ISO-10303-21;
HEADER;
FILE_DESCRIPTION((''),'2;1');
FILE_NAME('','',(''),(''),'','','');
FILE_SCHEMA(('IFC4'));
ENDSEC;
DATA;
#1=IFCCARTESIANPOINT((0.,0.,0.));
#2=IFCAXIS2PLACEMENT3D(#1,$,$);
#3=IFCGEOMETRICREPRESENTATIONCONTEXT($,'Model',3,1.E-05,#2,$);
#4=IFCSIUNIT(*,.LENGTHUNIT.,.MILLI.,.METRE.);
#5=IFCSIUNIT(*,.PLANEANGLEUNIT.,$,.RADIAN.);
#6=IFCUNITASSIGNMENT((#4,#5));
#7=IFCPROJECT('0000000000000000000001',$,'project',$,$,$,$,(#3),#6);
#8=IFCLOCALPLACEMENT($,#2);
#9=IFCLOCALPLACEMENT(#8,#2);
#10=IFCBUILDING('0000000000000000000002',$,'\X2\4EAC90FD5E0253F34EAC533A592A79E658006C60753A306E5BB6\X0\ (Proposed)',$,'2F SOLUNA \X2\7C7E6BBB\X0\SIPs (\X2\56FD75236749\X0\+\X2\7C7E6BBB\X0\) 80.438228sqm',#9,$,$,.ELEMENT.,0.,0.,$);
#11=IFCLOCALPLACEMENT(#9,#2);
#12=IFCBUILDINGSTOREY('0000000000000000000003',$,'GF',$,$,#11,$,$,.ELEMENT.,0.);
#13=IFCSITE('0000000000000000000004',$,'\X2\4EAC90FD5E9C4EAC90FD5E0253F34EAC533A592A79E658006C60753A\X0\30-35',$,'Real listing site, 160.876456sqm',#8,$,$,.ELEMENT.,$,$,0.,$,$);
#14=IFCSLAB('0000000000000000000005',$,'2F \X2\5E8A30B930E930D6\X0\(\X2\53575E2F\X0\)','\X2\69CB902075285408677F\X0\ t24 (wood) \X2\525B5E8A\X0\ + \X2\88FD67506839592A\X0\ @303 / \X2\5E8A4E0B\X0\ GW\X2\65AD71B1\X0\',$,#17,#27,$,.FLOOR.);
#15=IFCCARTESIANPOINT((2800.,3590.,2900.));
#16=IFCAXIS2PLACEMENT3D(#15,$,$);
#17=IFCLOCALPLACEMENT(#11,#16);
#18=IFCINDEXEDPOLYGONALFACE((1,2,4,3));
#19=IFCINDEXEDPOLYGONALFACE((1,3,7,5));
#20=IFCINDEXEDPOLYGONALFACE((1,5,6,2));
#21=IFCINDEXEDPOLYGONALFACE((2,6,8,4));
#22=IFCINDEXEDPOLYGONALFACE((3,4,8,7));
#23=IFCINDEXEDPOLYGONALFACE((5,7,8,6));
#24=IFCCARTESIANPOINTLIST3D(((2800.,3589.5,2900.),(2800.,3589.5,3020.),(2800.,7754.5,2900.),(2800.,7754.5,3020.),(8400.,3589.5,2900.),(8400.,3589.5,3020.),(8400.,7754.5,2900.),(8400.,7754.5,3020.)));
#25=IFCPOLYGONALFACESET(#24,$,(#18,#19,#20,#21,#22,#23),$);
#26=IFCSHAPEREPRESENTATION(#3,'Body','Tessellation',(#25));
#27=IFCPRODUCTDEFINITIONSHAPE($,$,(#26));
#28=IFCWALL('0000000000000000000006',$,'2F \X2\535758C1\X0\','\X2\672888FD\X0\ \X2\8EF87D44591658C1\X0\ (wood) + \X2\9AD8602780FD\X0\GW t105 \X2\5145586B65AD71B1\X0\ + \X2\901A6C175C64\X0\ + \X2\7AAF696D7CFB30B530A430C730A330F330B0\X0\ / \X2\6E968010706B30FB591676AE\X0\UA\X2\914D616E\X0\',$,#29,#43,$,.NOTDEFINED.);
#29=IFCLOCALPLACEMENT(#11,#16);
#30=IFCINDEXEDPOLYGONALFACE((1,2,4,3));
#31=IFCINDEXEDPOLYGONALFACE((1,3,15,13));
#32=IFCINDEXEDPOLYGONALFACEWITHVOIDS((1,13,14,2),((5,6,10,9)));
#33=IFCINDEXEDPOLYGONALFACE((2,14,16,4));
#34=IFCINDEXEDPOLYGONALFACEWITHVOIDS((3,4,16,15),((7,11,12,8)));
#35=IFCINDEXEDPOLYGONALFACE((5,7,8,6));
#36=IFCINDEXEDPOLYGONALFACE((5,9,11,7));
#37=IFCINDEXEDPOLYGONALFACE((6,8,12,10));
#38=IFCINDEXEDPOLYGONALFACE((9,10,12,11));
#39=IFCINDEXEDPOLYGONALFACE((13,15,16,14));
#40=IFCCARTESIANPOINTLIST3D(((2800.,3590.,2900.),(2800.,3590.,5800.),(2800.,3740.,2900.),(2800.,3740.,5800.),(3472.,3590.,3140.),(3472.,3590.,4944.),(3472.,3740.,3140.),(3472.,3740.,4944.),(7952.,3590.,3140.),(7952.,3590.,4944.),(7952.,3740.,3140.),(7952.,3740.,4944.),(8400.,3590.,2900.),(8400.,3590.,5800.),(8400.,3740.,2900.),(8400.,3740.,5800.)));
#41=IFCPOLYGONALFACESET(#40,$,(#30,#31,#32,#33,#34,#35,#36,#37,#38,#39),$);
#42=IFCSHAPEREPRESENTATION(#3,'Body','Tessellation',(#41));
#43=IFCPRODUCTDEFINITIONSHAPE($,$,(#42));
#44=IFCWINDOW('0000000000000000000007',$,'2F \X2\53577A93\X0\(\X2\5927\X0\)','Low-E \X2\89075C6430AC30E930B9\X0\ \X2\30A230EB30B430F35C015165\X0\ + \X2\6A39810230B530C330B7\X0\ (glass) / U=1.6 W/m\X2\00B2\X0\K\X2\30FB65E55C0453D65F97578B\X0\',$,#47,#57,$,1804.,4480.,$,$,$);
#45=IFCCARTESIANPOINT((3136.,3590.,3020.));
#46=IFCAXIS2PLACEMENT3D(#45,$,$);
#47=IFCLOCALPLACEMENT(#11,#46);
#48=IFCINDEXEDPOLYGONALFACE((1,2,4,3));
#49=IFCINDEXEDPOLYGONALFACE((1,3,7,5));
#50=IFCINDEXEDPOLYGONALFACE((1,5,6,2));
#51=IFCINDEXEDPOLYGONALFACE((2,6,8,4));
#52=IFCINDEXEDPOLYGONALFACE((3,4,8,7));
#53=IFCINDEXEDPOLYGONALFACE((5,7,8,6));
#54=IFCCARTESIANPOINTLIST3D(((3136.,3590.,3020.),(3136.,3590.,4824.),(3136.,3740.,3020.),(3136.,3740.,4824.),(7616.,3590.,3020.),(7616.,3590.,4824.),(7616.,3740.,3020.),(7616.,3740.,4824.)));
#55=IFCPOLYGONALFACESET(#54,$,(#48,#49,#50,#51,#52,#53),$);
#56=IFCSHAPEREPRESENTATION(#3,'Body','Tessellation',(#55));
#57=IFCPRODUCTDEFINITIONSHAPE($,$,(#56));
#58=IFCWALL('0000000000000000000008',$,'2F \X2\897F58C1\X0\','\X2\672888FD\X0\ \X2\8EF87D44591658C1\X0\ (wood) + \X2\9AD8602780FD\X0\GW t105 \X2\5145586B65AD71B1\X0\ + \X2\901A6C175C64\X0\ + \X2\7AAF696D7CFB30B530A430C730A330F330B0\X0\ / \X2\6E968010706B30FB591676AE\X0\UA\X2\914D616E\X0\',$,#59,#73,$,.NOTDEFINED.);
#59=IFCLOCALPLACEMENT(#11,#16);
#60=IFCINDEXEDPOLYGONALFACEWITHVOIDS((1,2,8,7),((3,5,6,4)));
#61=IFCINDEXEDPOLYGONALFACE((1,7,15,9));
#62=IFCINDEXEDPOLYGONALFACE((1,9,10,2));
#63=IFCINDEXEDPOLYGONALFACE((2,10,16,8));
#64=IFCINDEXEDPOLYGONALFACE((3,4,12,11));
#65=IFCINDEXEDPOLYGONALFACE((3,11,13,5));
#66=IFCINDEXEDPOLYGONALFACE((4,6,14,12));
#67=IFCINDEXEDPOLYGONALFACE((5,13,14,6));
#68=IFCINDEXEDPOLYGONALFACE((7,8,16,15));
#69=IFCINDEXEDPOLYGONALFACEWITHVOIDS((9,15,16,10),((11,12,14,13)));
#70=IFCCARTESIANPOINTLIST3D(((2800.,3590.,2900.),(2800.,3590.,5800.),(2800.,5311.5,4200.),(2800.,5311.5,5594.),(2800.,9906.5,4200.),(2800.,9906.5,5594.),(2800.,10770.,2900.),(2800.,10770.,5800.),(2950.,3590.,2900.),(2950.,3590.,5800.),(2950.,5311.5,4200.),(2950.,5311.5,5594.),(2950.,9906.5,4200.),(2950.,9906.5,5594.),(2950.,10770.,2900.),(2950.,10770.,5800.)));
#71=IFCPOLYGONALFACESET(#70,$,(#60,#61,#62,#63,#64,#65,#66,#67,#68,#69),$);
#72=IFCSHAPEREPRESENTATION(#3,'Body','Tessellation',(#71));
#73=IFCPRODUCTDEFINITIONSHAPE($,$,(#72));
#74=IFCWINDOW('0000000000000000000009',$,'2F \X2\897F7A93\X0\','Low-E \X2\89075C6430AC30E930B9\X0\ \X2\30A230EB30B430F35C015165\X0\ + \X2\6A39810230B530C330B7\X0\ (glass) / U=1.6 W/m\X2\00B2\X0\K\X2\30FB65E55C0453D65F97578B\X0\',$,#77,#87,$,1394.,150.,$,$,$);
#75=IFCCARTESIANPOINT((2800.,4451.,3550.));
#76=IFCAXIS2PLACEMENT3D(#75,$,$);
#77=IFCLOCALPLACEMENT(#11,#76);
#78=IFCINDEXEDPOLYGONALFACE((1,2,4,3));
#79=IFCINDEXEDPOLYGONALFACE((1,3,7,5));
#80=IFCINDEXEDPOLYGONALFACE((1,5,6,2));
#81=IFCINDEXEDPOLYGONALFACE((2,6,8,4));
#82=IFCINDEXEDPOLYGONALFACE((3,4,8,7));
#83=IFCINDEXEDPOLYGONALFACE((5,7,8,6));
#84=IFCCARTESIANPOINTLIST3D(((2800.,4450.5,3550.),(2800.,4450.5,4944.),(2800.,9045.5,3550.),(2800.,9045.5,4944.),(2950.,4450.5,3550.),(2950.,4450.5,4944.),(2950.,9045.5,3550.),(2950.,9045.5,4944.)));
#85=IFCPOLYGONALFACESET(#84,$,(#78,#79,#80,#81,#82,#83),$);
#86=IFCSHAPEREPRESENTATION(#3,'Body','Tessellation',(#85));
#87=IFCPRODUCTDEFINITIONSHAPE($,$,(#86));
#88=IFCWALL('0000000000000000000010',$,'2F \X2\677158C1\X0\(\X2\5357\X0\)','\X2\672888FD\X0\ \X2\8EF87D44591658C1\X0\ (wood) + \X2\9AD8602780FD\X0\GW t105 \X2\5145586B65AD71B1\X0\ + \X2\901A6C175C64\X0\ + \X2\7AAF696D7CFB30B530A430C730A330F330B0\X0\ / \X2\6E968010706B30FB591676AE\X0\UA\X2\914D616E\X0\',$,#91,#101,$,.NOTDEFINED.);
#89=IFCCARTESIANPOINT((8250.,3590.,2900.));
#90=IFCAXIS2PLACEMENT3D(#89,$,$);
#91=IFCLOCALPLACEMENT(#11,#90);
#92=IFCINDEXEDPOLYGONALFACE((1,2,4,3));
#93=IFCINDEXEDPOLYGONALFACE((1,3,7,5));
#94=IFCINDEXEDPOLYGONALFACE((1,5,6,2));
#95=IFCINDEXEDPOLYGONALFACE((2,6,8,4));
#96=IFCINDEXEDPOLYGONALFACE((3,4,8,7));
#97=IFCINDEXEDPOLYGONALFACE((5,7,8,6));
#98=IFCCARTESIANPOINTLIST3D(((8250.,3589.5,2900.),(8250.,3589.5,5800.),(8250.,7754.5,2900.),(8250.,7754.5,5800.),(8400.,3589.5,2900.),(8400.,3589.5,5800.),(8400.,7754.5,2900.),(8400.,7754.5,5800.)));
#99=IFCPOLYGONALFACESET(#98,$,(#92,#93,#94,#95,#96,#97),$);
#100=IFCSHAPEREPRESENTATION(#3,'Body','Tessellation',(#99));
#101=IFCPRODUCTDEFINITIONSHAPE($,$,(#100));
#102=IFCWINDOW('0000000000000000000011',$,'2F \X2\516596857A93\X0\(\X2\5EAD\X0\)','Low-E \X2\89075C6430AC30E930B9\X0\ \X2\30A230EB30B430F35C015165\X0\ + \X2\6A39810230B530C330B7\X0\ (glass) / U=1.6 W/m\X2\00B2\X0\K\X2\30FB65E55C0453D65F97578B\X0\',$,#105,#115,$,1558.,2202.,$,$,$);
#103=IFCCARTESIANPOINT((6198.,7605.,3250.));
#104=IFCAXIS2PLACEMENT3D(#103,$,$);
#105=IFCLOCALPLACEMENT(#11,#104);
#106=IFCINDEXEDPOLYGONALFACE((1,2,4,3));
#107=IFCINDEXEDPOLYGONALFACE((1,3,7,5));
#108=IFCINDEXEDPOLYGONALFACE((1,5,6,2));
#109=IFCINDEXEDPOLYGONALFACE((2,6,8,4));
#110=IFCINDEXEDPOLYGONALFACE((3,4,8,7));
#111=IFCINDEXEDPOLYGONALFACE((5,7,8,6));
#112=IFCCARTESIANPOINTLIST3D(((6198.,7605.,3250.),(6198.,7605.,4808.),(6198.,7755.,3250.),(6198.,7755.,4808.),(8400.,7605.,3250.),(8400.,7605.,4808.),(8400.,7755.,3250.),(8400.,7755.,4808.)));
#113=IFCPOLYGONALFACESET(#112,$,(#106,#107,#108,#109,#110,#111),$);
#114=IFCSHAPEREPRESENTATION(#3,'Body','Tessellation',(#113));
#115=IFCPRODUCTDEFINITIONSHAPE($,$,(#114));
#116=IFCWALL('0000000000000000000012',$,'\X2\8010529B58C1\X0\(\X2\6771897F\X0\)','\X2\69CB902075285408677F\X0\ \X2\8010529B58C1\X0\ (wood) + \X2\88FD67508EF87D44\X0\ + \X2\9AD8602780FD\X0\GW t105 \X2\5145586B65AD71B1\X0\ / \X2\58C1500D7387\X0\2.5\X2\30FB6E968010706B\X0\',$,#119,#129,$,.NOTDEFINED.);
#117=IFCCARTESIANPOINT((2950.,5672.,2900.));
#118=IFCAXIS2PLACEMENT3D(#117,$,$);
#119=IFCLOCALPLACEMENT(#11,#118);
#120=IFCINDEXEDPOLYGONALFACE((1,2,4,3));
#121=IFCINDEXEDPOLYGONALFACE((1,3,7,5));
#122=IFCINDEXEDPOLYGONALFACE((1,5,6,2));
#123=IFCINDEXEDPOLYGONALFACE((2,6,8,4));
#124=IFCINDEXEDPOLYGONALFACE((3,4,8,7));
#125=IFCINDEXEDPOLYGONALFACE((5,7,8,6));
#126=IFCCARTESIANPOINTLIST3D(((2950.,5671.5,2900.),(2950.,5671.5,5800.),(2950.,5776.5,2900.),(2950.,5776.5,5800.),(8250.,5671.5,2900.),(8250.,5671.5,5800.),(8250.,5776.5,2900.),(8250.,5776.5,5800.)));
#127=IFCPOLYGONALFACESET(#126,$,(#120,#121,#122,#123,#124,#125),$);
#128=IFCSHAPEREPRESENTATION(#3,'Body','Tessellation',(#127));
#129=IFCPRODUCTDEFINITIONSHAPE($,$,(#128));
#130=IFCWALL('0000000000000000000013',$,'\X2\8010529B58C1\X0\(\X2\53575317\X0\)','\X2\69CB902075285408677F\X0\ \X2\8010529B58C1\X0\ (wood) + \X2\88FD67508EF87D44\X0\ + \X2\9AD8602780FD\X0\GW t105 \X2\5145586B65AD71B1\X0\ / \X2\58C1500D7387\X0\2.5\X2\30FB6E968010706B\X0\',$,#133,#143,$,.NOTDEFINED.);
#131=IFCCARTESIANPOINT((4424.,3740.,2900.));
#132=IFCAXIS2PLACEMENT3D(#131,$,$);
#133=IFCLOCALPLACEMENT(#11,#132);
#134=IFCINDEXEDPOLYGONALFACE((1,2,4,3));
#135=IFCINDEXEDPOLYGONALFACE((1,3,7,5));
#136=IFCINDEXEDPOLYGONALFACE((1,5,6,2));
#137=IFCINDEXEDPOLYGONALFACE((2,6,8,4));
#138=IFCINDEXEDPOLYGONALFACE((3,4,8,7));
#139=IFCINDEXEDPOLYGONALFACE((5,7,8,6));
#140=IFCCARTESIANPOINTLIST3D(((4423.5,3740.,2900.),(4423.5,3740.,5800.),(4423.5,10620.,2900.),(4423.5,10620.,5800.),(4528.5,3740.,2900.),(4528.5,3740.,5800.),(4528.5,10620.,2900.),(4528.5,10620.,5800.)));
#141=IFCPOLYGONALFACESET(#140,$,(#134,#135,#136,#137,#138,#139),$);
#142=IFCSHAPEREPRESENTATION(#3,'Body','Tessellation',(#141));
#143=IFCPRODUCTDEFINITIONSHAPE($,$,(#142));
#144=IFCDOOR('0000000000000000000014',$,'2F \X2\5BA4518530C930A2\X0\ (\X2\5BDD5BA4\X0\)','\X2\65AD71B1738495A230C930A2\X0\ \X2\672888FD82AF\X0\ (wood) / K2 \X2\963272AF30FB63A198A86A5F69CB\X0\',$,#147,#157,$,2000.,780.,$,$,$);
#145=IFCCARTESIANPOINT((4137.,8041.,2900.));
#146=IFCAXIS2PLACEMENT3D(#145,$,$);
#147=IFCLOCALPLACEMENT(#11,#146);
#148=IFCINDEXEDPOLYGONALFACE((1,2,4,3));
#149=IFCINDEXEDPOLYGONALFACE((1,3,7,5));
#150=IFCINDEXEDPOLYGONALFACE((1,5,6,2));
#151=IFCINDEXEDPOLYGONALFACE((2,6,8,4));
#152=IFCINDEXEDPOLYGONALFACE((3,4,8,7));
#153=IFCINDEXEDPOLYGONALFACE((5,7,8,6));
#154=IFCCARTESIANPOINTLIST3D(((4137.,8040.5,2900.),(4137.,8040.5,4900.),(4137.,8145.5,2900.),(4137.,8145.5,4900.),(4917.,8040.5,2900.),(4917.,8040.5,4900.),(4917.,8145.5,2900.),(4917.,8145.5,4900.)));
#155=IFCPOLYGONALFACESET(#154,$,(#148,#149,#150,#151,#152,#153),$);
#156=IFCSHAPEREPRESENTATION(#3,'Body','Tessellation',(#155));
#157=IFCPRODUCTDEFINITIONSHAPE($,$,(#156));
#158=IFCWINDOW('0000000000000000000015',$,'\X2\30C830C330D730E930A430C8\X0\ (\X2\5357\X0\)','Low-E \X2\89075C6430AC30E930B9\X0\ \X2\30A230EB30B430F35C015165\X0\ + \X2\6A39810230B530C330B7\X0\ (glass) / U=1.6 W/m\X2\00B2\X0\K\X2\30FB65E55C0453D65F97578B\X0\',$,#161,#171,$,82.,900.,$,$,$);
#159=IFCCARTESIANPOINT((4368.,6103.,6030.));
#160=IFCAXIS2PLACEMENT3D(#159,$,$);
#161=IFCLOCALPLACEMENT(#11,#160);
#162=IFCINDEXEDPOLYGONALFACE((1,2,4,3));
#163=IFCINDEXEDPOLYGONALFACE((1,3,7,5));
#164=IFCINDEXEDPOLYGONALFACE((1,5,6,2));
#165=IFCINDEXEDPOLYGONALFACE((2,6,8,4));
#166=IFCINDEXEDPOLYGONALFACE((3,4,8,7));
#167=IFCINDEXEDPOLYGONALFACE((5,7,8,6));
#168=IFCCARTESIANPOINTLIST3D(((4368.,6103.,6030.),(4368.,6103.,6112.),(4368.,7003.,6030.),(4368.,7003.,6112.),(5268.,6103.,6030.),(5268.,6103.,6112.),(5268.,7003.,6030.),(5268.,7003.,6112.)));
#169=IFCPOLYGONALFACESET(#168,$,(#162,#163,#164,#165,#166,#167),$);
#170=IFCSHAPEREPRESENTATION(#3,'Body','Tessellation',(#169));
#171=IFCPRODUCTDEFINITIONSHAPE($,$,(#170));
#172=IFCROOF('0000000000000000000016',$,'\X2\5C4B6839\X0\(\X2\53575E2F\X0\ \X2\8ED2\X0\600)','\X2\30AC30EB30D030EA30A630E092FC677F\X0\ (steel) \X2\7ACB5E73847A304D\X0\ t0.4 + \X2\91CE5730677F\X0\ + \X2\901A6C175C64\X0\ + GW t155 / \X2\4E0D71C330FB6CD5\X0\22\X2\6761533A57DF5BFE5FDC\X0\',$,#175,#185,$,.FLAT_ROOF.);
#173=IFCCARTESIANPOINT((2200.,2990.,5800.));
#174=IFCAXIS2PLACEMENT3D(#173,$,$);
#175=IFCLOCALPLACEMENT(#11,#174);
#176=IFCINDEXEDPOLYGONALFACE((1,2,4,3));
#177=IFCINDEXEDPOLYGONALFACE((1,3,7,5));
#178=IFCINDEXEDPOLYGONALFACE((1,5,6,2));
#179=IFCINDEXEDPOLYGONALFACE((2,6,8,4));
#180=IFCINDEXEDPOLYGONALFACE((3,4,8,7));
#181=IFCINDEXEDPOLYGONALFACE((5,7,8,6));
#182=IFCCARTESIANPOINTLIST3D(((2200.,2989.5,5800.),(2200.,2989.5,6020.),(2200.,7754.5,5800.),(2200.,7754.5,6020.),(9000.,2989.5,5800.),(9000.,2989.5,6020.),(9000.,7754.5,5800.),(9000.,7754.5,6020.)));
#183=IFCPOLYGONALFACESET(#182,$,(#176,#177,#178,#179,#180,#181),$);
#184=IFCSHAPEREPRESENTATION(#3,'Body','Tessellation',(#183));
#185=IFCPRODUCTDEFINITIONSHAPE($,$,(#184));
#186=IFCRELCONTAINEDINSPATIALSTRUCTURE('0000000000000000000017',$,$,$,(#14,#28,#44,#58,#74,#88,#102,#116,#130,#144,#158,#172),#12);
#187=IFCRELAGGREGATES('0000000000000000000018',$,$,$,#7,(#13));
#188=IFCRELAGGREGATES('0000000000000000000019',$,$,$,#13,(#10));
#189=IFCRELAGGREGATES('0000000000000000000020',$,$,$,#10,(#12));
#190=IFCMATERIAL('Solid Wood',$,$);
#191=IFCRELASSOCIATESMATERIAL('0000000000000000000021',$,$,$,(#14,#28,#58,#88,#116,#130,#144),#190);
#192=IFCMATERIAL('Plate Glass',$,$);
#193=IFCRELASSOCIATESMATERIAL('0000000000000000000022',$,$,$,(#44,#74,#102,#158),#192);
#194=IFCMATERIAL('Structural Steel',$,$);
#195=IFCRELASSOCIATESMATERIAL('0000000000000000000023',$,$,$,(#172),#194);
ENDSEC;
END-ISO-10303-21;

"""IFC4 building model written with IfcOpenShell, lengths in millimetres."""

from ifc_helpers import new_model, si_unit, frame, frame_2d, origin, place, context, project, spatial, rectangle, extrude, material, element, fill, save


model = new_model("IFC4")

# Units and contexts
model_context = context("Model", 3, precision=1e-05, world=origin())
ifc_project = project(units=[si_unit("LENGTHUNIT", "METRE", prefix="MILLI"), si_unit("PLANEANGLEUNIT", "RADIAN")], contexts=[model_context])

# Site, building, storey
site_placement = place(None, origin())
site = spatial("IfcSite", under=ifc_project, at=site_placement, Name="京都府京都市右京区太秦堀池町30-35", ObjectType="Real listing site, 160.876456sqm", CompositionType="ELEMENT", RefElevation=0.0)
building_placement = place(site_placement, origin())
building = spatial("IfcBuilding", under=site, at=building_placement, Name="京都市右京区太秦堀池町の家 (Proposed)", ObjectType="2F SOLUNA 籾殻SIPs (国産杉+籾殻) 80.438228sqm", CompositionType="ELEMENT", ElevationOfRefHeight=0.0, ElevationOfTerrain=0.0)
storey_placement = place(building_placement, origin())
storey = spatial("IfcBuildingStorey", under=building, at=storey_placement, Name="GF", CompositionType="ELEMENT", Elevation=0.0)

# Slab
ifc_material_1 = material(Name="Solid Wood")
slab_placement = place(storey_placement, frame((2800.0, 3590.0, 2900.0)))
element("IfcSlab", 1, at=slab_placement, inside=storey, material=ifc_material_1, Name="2F 床スラブ(南帯)", Description="構造用合板 t24 (wood) 剛床 + 製材根太 @303 / 床下 GW断熱", PredefinedType="FLOOR", context=model_context, shape_type="SweptSolid", body=[
    extrude(rectangle(XDim=5600.0, YDim=4165.0, at=frame_2d((2800.0, 2082.0))), frame((2800.0, 3590.0, 2900.0)), (0.0, 0.0, 1.0), 120.0),
])

# Walls, openings, windows
wall_1_placement = place(storey_placement, frame((2800.0, 3590.0, 2900.0)))
wall_1 = element("IfcWall", 2, at=wall_1_placement, inside=storey, material=ifc_material_1, Name="2F 南壁", Description="木製 軸組外壁 (wood) + 高性能GW t105 充填断熱 + 通気層 + 窯業系サイディング / 準耐火・外皮UA配慮", PredefinedType="NOTDEFINED", context=model_context, shape_type="SweptSolid", body=[
    extrude(rectangle(XDim=5600.0, YDim=150.0, at=frame_2d((2800.0, 75.0))), frame((2800.0, 3590.0, 2900.0)), (0.0, 0.0, 1.0), 2900.0),
])
opening_1_placement = place(storey_placement, frame((3136.0, 3590.0, 3020.0)))
opening_1 = element("IfcOpeningElement", 3, at=opening_1_placement, cuts=wall_1, PredefinedType="NOTDEFINED", context=model_context, shape_type="SweptSolid", body=[
    extrude(rectangle(XDim=4480.0, YDim=150.0, at=frame_2d((2240.0, 75.0))), frame((3136.0, 3590.0, 3020.0)), (0.0, 0.0, 1.0), 1804.0),
])
ifc_material_2 = material(Name="Plate Glass")
window_1_placement = place(storey_placement, frame((3136.0, 3590.0, 3020.0)))
window_1 = element("IfcWindow", 4, at=window_1_placement, inside=storey, material=ifc_material_2, Name="2F 南窓(大)", Description="Low-E 複層ガラス アルゴン封入 + 樹脂サッシ (glass) / U=1.6 W/m²K・日射取得型", OverallHeight=1804.0, OverallWidth=4480.0, context=model_context, shape_type="SweptSolid", body=[
    extrude(rectangle(XDim=4480.0, YDim=150.0, at=frame_2d((2240.0, 75.0))), frame((3136.0, 3590.0, 3020.0)), (0.0, 0.0, 1.0), 1804.0),
])
fill(opening_1, window_1)
wall_2_placement = place(storey_placement, frame((2800.0, 3590.0, 2900.0)))
wall_2 = element("IfcWall", 5, at=wall_2_placement, inside=storey, material=ifc_material_1, Name="2F 西壁", Description="木製 軸組外壁 (wood) + 高性能GW t105 充填断熱 + 通気層 + 窯業系サイディング / 準耐火・外皮UA配慮", PredefinedType="NOTDEFINED", context=model_context, shape_type="SweptSolid", body=[
    extrude(rectangle(XDim=150.0, YDim=7180.0, at=frame_2d((75.0, 3590.0))), frame((2800.0, 3590.0, 2900.0)), (0.0, 0.0, 1.0), 2900.0),
])
opening_2_placement = place(storey_placement, frame((2800.0, 4451.0, 3550.0)))
opening_2 = element("IfcOpeningElement", 6, at=opening_2_placement, cuts=wall_2, PredefinedType="NOTDEFINED", context=model_context, shape_type="SweptSolid", body=[
    extrude(rectangle(XDim=150.0, YDim=4595.0, at=frame_2d((75.0, 2297.0))), frame((2800.0, 4451.0, 3550.0)), (0.0, 0.0, 1.0), 1394.0),
])
window_2_placement = place(storey_placement, frame((2800.0, 4451.0, 3550.0)))
window_2 = element("IfcWindow", 7, at=window_2_placement, inside=storey, material=ifc_material_2, Name="2F 西窓", Description="Low-E 複層ガラス アルゴン封入 + 樹脂サッシ (glass) / U=1.6 W/m²K・日射取得型", OverallHeight=1394.0, OverallWidth=150.0, context=model_context, shape_type="SweptSolid", body=[
    extrude(rectangle(XDim=150.0, YDim=4595.0, at=frame_2d((75.0, 2297.0))), frame((2800.0, 4451.0, 3550.0)), (0.0, 0.0, 1.0), 1394.0),
])
fill(opening_2, window_2)
wall_3_placement = place(storey_placement, frame((8250.0, 3590.0, 2900.0)))
wall_3 = element("IfcWall", 8, at=wall_3_placement, inside=storey, material=ifc_material_1, Name="2F 東壁(南)", Description="木製 軸組外壁 (wood) + 高性能GW t105 充填断熱 + 通気層 + 窯業系サイディング / 準耐火・外皮UA配慮", PredefinedType="NOTDEFINED", context=model_context, shape_type="SweptSolid", body=[
    extrude(rectangle(XDim=150.0, YDim=4165.0, at=frame_2d((75.0, 2082.0))), frame((8250.0, 3590.0, 2900.0)), (0.0, 0.0, 1.0), 2900.0),
])
opening_3_placement = place(storey_placement, frame((6198.0, 7605.0, 3250.0)))
opening_3 = element("IfcOpeningElement", 9, at=opening_3_placement, cuts=wall_3, PredefinedType="NOTDEFINED", context=model_context, shape_type="SweptSolid", body=[
    extrude(rectangle(XDim=2202.0, YDim=150.0, at=frame_2d((1101.0, 75.0))), frame((6198.0, 7605.0, 3250.0)), (0.0, 0.0, 1.0), 1558.0),
])
window_3_placement = place(storey_placement, frame((6198.0, 7605.0, 3250.0)))
window_3 = element("IfcWindow", 10, at=window_3_placement, inside=storey, material=ifc_material_2, Name="2F 入隅窓(庭)", Description="Low-E 複層ガラス アルゴン封入 + 樹脂サッシ (glass) / U=1.6 W/m²K・日射取得型", OverallHeight=1558.0, OverallWidth=2202.0, context=model_context, shape_type="SweptSolid", body=[
    extrude(rectangle(XDim=2202.0, YDim=150.0, at=frame_2d((1101.0, 75.0))), frame((6198.0, 7605.0, 3250.0)), (0.0, 0.0, 1.0), 1558.0),
])
fill(opening_3, window_3)

# Wall
wall_4_placement = place(storey_placement, frame((2950.0, 5672.0, 2900.0)))
element("IfcWall", 11, at=wall_4_placement, inside=storey, material=ifc_material_1, Name="耐力壁(東西)", Description="構造用合板 耐力壁 (wood) + 製材軸組 + 高性能GW t105 充填断熱 / 壁倍率2.5・準耐火", PredefinedType="NOTDEFINED", context=model_context, shape_type="SweptSolid", body=[
    extrude(rectangle(XDim=5300.0, YDim=105.0, at=frame_2d((2650.0, 52.0))), frame((2950.0, 5672.0, 2900.0)), (0.0, 0.0, 1.0), 2900.0),
])

# Wall, opening, door
wall_5_placement = place(storey_placement, frame((4424.0, 3740.0, 2900.0)))
wall_5 = element("IfcWall", 12, at=wall_5_placement, inside=storey, material=ifc_material_1, Name="耐力壁(南北)", Description="構造用合板 耐力壁 (wood) + 製材軸組 + 高性能GW t105 充填断熱 / 壁倍率2.5・準耐火", PredefinedType="NOTDEFINED", context=model_context, shape_type="SweptSolid", body=[
    extrude(rectangle(XDim=105.0, YDim=6880.0, at=frame_2d((52.0, 3440.0))), frame((4424.0, 3740.0, 2900.0)), (0.0, 0.0, 1.0), 2900.0),
])
opening_4_placement = place(storey_placement, frame((4137.0, 8041.0, 2900.0)))
opening_4 = element("IfcOpeningElement", 13, at=opening_4_placement, cuts=wall_5, PredefinedType="NOTDEFINED", context=model_context, shape_type="SweptSolid", body=[
    extrude(rectangle(XDim=780.0, YDim=105.0, at=frame_2d((390.0, 52.0))), frame((4137.0, 8041.0, 2900.0)), (0.0, 0.0, 1.0), 2000.0),
])
door_placement = place(storey_placement, frame((4137.0, 8041.0, 2900.0)))
door = element("IfcDoor", 14, at=door_placement, inside=storey, material=ifc_material_1, Name="2F 室内ドア (寝室)", Description="断熱玄関ドア 木製芯 (wood) / K2 防犯・採風機構", OverallHeight=2000.0, OverallWidth=780.0, context=model_context, shape_type="SweptSolid", body=[
    extrude(rectangle(XDim=780.0, YDim=105.0, at=frame_2d((390.0, 52.0))), frame((4137.0, 8041.0, 2900.0)), (0.0, 0.0, 1.0), 2000.0),
])
fill(opening_4, door)

# Window
window_4_placement = place(storey_placement, frame((4368.0, 6103.0, 6030.0)))
element("IfcWindow", 15, at=window_4_placement, inside=storey, material=ifc_material_2, Name="トップライト (南)", Description="Low-E 複層ガラス アルゴン封入 + 樹脂サッシ (glass) / U=1.6 W/m²K・日射取得型", OverallHeight=82.0, OverallWidth=900.0, context=model_context, shape_type="SweptSolid", body=[
    extrude(rectangle(XDim=900.0, YDim=900.0, at=frame_2d((450.0, 450.0))), frame((4368.0, 6103.0, 6030.0)), (0.0, 0.0, 1.0), 82.0),
])

# Roof
ifc_material_3 = material(Name="Structural Steel")
for number, where, name in (
    (16, (2200.0, 2990.0, 5800.0), "屋根(南帯 軒600)"),
):
    element("IfcRoof", number, at=place(storey_placement, frame(where)), inside=storey, material=ifc_material_3, Name=name, Description="ガルバリウム鋼板 (steel) 立平葺き t0.4 + 野地板 + 通気層 + GW t155 / 不燃・法22条区域対応", PredefinedType="FLAT_ROOF", context=model_context, shape_type="SweptSolid", body=[
        extrude(rectangle(XDim=6800.0, YDim=4765.0, at=frame_2d((3400.0, 2382.0))), frame((2200.0, 2990.0, 5800.0)), (0.0, 0.0, 1.0), 220.0),
    ])

save(model, "model.ifc")
